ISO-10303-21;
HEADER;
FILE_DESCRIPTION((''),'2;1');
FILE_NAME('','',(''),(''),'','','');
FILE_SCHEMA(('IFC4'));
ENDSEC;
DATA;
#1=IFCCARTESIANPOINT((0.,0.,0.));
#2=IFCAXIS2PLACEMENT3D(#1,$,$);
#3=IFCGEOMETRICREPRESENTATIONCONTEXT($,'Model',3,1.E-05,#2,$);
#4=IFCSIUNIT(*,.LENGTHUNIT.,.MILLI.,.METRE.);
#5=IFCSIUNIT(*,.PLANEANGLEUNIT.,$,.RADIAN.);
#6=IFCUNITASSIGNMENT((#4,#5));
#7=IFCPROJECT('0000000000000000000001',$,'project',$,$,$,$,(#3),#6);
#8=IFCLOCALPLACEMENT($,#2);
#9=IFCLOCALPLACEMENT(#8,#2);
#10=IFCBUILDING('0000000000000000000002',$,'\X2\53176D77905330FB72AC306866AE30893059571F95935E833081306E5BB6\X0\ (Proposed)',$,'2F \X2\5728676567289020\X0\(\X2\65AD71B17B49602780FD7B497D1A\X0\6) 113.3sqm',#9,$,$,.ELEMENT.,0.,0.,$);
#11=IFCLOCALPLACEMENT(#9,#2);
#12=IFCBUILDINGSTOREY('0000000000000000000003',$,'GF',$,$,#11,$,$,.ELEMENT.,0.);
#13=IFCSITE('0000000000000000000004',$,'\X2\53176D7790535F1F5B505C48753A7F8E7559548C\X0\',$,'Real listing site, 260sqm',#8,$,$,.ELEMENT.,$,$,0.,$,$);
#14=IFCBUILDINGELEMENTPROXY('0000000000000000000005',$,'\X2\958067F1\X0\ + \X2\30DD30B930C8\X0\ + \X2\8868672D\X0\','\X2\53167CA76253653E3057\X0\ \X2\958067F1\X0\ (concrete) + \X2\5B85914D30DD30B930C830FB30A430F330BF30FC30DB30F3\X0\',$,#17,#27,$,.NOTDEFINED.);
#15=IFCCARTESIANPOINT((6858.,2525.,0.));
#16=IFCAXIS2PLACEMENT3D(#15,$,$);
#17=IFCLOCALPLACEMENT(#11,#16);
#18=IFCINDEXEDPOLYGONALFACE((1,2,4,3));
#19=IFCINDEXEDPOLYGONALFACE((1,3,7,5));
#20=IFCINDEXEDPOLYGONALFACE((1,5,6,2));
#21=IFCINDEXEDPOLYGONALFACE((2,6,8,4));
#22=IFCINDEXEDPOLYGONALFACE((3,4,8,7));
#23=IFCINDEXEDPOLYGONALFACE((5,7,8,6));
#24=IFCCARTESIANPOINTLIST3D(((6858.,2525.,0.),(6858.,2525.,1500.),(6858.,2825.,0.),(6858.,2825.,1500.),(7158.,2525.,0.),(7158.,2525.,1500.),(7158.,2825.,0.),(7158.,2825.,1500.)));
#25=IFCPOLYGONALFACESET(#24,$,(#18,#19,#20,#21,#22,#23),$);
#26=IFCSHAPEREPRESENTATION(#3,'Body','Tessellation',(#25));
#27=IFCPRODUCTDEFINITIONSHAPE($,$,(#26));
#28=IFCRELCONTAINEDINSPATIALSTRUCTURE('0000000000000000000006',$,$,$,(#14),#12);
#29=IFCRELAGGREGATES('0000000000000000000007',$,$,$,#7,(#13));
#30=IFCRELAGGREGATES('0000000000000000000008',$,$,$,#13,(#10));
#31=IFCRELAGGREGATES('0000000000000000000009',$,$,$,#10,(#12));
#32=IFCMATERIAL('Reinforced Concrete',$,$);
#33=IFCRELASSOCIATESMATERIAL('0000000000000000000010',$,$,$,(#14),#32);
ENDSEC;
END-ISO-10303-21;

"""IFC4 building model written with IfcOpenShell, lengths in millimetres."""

from ifc_helpers import new_model, si_unit, frame, frame_2d, origin, place, context, project, spatial, rectangle, extrude, material, element, save


model = new_model("IFC4")

# Units and contexts
model_context = context("Model", 3, precision=1e-05, world=origin())
ifc_project = project(units=[si_unit("LENGTHUNIT", "METRE", prefix="MILLI"), si_unit("PLANEANGLEUNIT", "RADIAN")], contexts=[model_context])

# Site, building, storey
site_placement = place(None, origin())
site = spatial("IfcSite", under=ifc_project, at=site_placement, Name="北海道弟子屈町美留和", ObjectType="Real listing site, 260sqm", CompositionType="ELEMENT", RefElevation=0.0)
building_placement = place(site_placement, origin())
building = spatial("IfcBuilding", under=site, at=building_placement, Name="北海道・犬と暮らす土間広めの家 (Proposed)", ObjectType="2F 在来木造(断熱等性能等級6) 113.3sqm", CompositionType="ELEMENT", ElevationOfRefHeight=0.0, ElevationOfTerrain=0.0)
storey_placement = place(building_placement, origin())
storey = spatial("IfcBuildingStorey", under=building, at=storey_placement, Name="GF", CompositionType="ELEMENT", Elevation=0.0)

# Shared definitions
ifc_material_1 = material(Name="Reinforced Concrete")

# Building element proxy
proxy_placement = place(storey_placement, frame((6858.0, 2525.0, 0.0)))
element("IfcBuildingElementProxy", 1, at=proxy_placement, inside=storey, material=ifc_material_1, Name="門柱 + ポスト + 表札", Description="化粧打放し 門柱 (concrete) + 宅配ポスト・インターホン", PredefinedType="NOTDEFINED", context=model_context, shape_type="SweptSolid", body=[
    extrude(rectangle(XDim=300.0, YDim=300.0, at=frame_2d((150.0, 150.0))), frame((6858.0, 2525.0, 0.0)), (0.0, 0.0, 1.0), 1500.0),
])

save(model, "model.ifc")
